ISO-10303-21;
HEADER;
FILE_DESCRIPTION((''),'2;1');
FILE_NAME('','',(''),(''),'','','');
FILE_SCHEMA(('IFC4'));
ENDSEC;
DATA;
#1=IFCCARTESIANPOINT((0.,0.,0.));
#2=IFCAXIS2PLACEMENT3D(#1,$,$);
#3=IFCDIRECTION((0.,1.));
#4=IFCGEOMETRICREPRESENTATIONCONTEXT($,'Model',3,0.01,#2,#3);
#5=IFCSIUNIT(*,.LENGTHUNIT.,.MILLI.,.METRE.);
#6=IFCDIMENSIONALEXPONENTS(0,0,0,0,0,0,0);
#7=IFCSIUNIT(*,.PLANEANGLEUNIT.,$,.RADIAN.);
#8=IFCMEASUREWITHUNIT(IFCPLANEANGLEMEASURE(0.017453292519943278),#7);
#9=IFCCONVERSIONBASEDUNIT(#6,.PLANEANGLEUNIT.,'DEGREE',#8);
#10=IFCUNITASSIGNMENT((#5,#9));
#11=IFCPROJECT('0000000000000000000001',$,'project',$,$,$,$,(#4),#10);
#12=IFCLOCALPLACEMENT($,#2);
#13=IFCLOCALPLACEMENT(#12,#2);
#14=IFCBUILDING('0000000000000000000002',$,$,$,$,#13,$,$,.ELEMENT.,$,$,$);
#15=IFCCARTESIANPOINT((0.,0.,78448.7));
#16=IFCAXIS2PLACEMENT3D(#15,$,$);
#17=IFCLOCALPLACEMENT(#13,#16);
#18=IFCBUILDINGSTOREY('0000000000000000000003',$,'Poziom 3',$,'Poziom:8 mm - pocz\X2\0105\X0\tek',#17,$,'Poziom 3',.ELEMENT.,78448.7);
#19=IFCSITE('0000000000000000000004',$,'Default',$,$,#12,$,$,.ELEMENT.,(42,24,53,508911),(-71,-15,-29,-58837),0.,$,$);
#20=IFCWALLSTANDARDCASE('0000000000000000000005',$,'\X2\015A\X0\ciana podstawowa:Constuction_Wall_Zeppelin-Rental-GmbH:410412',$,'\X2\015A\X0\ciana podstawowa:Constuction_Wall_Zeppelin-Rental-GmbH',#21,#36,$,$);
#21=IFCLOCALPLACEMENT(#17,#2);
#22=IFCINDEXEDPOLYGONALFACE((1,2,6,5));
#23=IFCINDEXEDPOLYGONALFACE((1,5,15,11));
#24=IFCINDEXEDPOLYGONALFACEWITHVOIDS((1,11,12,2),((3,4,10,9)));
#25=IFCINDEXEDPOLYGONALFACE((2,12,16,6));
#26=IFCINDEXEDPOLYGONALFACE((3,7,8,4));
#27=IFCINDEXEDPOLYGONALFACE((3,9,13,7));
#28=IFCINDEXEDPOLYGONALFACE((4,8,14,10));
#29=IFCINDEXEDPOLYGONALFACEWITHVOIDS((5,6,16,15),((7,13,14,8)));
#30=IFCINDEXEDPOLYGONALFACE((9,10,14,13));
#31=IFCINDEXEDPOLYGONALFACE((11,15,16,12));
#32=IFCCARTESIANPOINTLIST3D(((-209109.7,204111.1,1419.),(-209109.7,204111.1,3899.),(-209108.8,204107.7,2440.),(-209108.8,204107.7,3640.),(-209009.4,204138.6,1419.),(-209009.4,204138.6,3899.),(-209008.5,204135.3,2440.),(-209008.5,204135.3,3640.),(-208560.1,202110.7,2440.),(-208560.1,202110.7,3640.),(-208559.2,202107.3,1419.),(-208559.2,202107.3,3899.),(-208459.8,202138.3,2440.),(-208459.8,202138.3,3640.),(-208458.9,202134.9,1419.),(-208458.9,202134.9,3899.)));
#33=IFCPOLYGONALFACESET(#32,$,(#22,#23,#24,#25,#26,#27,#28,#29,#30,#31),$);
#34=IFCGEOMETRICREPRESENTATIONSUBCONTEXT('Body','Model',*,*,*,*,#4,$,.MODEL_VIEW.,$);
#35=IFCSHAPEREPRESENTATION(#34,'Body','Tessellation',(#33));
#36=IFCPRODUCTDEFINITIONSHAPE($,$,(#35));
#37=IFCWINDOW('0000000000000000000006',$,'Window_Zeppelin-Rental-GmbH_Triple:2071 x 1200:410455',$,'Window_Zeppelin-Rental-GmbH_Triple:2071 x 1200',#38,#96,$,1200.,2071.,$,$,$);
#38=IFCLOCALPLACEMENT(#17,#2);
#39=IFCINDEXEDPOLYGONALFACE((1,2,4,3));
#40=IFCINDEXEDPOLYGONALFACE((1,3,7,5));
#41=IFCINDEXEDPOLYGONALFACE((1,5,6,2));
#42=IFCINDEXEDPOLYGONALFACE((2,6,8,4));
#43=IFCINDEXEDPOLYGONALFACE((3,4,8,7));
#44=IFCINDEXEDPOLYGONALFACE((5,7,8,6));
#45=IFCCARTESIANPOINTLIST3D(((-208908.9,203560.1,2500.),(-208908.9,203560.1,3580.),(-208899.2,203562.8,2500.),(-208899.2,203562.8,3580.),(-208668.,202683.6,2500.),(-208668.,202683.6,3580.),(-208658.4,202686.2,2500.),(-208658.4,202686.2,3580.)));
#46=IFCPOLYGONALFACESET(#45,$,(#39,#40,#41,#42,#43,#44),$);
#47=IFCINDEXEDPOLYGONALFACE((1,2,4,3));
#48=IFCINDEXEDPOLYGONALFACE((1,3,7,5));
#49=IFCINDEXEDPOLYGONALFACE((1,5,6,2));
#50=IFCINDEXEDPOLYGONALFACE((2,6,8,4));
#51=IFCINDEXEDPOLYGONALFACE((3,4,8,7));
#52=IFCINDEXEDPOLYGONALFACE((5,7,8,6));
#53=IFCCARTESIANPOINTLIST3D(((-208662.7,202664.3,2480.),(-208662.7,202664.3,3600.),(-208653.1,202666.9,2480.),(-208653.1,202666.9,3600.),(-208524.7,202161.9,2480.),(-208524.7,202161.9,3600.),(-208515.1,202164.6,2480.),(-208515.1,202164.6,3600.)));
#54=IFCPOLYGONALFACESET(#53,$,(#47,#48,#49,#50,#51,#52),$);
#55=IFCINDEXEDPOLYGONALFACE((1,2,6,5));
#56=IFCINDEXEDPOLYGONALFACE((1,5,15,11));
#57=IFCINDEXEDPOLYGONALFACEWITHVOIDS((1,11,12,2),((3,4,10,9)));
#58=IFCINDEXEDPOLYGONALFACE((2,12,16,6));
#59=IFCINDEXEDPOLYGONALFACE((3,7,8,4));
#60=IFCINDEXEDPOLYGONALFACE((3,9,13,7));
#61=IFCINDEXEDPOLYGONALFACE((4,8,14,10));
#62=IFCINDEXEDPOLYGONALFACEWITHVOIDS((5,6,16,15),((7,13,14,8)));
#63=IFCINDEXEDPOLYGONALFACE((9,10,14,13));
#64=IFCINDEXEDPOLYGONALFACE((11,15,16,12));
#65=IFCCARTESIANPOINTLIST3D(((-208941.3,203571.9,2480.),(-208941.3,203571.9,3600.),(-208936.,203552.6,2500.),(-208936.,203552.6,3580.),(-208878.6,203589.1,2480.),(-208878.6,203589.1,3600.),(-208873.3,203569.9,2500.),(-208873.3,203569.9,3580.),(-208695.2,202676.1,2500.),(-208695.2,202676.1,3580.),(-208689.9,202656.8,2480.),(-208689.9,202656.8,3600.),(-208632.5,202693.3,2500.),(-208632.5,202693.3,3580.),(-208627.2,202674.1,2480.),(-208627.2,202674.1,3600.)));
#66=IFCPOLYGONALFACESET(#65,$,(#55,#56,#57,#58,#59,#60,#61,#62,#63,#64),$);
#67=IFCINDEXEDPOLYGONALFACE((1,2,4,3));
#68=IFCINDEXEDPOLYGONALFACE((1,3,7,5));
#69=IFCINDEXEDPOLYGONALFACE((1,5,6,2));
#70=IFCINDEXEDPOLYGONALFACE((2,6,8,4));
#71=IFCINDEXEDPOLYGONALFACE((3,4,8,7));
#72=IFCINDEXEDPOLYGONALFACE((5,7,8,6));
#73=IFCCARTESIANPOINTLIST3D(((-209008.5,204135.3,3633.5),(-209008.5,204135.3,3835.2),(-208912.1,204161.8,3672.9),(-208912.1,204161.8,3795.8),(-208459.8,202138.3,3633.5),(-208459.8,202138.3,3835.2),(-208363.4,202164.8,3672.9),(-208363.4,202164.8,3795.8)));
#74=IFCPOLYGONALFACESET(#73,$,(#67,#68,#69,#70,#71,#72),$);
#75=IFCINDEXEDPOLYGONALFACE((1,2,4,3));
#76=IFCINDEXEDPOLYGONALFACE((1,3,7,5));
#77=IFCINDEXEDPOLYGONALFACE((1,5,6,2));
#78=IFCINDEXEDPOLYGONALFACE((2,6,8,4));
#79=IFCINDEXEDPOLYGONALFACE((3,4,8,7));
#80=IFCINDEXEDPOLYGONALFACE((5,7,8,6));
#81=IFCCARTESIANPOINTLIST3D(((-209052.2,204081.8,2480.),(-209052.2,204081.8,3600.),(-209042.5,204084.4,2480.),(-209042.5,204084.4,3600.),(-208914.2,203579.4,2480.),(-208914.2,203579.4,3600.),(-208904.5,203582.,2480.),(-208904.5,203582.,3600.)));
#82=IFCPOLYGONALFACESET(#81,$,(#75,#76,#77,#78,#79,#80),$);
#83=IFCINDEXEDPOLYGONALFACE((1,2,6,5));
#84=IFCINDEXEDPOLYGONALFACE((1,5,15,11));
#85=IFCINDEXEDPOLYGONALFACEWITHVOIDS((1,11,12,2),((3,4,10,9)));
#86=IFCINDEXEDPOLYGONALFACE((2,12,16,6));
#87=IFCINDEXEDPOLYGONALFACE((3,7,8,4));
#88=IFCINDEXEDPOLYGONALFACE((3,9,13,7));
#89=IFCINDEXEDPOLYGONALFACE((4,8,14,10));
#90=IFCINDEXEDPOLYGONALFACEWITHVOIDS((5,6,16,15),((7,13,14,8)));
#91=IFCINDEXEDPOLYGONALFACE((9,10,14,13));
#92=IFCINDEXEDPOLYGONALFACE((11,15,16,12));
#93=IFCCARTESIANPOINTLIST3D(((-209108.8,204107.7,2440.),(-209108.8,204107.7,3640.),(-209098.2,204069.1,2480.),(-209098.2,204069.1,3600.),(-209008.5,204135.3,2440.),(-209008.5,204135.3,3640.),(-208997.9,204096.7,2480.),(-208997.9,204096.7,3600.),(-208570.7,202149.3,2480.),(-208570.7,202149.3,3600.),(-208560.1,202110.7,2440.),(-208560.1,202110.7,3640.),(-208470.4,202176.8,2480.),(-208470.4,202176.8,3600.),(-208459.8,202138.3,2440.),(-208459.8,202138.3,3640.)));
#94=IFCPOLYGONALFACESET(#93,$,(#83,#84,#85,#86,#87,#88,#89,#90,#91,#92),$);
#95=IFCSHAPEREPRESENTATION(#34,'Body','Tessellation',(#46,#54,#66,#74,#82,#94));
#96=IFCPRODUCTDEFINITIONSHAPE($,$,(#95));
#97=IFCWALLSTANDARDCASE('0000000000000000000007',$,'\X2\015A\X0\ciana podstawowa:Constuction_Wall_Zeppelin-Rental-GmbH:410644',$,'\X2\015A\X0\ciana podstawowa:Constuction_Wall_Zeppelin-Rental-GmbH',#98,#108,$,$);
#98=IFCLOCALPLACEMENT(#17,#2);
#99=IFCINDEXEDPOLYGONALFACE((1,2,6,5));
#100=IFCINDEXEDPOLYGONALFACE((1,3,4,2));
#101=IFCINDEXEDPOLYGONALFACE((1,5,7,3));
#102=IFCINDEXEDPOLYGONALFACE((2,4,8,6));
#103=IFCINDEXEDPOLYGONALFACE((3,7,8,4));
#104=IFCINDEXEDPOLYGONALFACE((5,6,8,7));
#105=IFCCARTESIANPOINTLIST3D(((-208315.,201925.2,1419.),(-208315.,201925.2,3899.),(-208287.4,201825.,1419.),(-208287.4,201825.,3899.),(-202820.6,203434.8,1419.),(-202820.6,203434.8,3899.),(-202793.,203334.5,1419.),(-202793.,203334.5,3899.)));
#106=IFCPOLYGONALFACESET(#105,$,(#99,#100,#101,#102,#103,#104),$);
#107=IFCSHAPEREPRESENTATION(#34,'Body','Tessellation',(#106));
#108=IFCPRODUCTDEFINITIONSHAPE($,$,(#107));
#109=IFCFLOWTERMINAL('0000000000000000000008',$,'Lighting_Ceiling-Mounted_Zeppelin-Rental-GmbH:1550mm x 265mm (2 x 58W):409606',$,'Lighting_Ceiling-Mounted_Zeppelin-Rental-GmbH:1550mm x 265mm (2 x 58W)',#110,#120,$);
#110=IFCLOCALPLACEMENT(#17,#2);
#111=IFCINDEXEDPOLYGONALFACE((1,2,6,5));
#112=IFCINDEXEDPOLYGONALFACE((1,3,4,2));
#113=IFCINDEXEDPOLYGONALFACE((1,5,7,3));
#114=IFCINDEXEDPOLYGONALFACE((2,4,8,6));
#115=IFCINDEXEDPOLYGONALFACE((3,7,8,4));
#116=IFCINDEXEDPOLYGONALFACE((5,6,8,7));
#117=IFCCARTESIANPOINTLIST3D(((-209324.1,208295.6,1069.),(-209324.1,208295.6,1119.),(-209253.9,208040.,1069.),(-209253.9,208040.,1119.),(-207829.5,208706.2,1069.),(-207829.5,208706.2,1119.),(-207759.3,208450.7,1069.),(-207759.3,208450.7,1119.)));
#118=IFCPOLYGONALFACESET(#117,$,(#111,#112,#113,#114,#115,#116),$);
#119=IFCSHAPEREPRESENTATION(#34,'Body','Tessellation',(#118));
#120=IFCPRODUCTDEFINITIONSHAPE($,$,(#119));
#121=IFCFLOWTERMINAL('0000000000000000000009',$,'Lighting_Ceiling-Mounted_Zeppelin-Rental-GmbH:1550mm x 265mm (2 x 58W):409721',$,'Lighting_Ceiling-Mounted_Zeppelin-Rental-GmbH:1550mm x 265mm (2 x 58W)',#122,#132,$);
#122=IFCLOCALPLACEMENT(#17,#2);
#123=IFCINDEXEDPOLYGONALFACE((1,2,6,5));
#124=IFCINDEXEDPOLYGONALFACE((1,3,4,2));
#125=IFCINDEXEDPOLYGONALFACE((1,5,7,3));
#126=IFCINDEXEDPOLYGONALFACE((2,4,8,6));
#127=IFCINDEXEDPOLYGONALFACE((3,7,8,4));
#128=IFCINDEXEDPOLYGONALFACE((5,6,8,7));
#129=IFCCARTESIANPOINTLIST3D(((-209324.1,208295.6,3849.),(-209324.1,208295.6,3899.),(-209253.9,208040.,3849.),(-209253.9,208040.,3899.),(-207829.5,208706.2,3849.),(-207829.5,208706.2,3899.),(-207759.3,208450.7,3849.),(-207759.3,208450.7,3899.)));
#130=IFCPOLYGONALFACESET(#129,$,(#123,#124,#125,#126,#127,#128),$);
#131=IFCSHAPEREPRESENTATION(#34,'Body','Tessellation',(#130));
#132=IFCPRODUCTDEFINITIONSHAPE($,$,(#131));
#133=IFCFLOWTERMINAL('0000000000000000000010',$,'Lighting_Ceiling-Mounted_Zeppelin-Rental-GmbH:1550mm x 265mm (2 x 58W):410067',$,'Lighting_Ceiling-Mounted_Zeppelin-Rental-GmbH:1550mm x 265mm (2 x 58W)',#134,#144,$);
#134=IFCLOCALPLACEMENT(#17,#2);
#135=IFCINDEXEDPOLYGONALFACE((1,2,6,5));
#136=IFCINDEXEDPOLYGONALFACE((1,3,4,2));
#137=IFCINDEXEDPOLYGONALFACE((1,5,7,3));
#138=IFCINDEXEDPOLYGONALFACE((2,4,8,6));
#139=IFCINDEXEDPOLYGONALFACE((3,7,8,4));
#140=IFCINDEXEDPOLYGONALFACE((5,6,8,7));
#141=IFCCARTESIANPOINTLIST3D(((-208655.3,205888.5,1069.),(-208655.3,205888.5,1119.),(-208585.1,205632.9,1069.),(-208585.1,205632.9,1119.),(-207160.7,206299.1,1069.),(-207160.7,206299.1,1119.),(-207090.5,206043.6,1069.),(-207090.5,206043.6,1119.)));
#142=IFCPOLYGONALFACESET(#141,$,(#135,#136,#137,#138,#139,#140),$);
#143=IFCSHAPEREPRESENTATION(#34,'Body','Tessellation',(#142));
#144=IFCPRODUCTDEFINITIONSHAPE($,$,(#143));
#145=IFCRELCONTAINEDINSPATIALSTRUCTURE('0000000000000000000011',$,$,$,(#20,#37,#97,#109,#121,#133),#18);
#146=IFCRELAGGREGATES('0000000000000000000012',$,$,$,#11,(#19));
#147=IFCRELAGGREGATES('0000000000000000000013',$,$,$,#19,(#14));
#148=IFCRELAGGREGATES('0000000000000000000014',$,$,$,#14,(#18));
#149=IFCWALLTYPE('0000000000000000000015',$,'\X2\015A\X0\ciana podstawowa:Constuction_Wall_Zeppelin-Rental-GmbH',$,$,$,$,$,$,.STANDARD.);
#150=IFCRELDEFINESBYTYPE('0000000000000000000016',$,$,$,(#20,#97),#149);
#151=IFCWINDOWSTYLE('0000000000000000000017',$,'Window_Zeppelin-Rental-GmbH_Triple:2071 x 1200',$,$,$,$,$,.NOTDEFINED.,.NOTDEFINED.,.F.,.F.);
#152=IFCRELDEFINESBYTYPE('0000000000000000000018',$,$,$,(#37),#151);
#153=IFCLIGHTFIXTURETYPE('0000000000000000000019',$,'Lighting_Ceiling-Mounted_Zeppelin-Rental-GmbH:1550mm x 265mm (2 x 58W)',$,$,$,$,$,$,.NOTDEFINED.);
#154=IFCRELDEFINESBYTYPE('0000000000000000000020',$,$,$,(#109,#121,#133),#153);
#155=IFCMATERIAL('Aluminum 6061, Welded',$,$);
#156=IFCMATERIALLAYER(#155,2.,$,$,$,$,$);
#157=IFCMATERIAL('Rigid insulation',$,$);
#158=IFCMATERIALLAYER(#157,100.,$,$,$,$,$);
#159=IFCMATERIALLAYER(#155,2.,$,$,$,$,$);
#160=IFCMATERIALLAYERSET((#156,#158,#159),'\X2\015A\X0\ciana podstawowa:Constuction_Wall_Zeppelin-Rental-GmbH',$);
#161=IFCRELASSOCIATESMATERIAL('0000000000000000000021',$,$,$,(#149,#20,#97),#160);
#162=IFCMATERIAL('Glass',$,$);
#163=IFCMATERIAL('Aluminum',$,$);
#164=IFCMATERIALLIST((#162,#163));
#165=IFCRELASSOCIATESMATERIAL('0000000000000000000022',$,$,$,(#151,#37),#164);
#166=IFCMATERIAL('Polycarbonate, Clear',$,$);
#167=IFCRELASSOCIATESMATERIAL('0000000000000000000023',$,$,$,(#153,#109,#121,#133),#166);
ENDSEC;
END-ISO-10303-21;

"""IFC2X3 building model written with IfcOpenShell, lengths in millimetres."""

from ifc_helpers import new_model, entity, si_unit, converted_unit, direction, frame, frame_2d, origin, origin_2d_with_axis, place, context, subcontext, project, spatial, polyline, rectangle, outline, extrude, source, transform, mapped, material, material_list, layer, layer_set, layer_usage, type_object, type_shapes, element, fill, save


model = new_model("IFC2X3")

# Units and contexts
model_context = context("Model", 3, precision=0.01, world=origin(), true_north=direction((0.0, 1.0)))
body_context = subcontext(model_context, "Body", "Model", "MODEL_VIEW")
ifc_project = project(units=[si_unit("LENGTHUNIT", "METRE", prefix="MILLI"), converted_unit("PLANEANGLEUNIT", "DEGREE", entity("IfcPlaneAngleMeasure", 0.017453292519943278), si_unit("PLANEANGLEUNIT", "RADIAN"), dimensions=[0, 0, 0, 0, 0, 0, 0])], contexts=[model_context])

# Site, building, storey
site_placement = place(None, origin())
site = spatial("IfcSite", under=ifc_project, at=site_placement, Name="Default", CompositionType="ELEMENT", RefLatitude=(42, 24, 53, 508911), RefLongitude=(-71, -15, -29, -58837), RefElevation=0.0)
building_placement = place(site_placement, origin())
building = spatial("IfcBuilding", under=site, at=building_placement, CompositionType="ELEMENT")
storey_placement = place(building_placement, frame((0.0, 0.0, 78448.7)))
storey = spatial("IfcBuildingStorey", under=building, at=storey_placement, Name="Poziom 3", ObjectType="Poziom:8 mm - początek", LongName="Poziom 3", CompositionType="ELEMENT", Elevation=78448.7)

# Shared definitions
ifc_material_1 = material(Name="Aluminum 6061, Welded")
ifc_layer_1 = layer(ifc_material_1, 2.0)
ifc_material_2 = material(Name="Rigid insulation")
ifc_layer_2 = layer(ifc_material_2, 100.0)
ifc_layer_3 = layer(ifc_material_1, 2.0)
ifc_layer_set_1 = layer_set([ifc_layer_1, ifc_layer_2, ifc_layer_3], Name="Ściana podstawowa:Constuction_Wall_Zeppelin-Rental-GmbH")
wall_type_1 = type_object("IfcWallType", Name="Ściana podstawowa:Constuction_Wall_Zeppelin-Rental-GmbH", PredefinedType="STANDARD", material=ifc_layer_set_1)

# Shared definitions
ifc_material_3 = material(Name="Glass")
ifc_material_4 = material(Name="Aluminum")
ifc_material_list = material_list([ifc_material_3, ifc_material_4])
window_style = type_object("IfcWindowStyle", Name="Window_Zeppelin-Rental-GmbH_Triple:2071 x 1200", ConstructionType="NOTDEFINED", OperationType="NOTDEFINED", ParameterTakesPrecedence=False, Sizeable=False, material=ifc_material_list)
shared_shape_1 = source(origin(), body_context, "Body", "SweptSolid", [
    extrude(rectangle(XDim=10.0, YDim=909.0, at=origin_2d_with_axis()), frame((1035.5, 52.7, 60.0), z_axis=(0.0, 0.0, 1.0), x_axis=(0.0, -1.0, 0.0)), (0.0, 0.0, 1.0), 1080.0),
    extrude(rectangle(XDim=521.0, YDim=10.0, at=frame_2d((0.0, 0.0), x_axis=(1.0, 0.0))), frame((300.5, 52.7, 40.0), z_axis=(0.0, 0.0, 1.0), x_axis=(-1.0, 0.0, 0.0)), (0.0, 0.0, 1.0), 1120.0),
    extrude(outline(polyline([(-474.5, -560.0), (474.5, -560.0), (474.5, 560.0), (-474.5, 560.0), (-474.5, -560.0)]), holes=[polyline([(-454.5, 540.0), (454.5, 540.0), (454.5, -540.0), (-454.5, -540.0), (-454.5, 540.0)])]), frame((1035.5, 85.8, 600.0), z_axis=(0.0, -1.0, 0.0), x_axis=(1.0, 0.0, 0.0)), (0.0, 0.0, 1.0), 65.0),
    extrude(outline(polyline([(-24.0, -75.5), (83.5, -75.5), (9.6, 112.1), (-69.0, 38.9), (-24.0, -75.5)])), frame((2071.0, -48.7, 1294.4), z_axis=(-1.0, 0.0, 0.0), x_axis=(0.0, 0.930458, 0.366398)), (0.0, 0.0, 1.0), 2071.0),
    extrude(rectangle(XDim=10.0, YDim=521.0, at=frame_2d((0.0, 0.0), x_axis=(1.0, 0.0))), frame((1770.5, 52.7, 40.0), z_axis=(0.0, 0.0, 1.0), x_axis=(0.0, -1.0, 0.0)), (0.0, 0.0, 1.0), 1120.0),
    extrude(outline(polyline([(-1035.5, -600.0), (1035.5, -600.0), (1035.5, 600.0), (-1035.5, 600.0), (-1035.5, -600.0)]), holes=[polyline([(-995.5, 560.0), (995.5, 560.0), (995.5, -560.0), (-995.5, -560.0), (-995.5, 560.0)])]), frame((1035.5, 105.3, 600.0), z_axis=(0.0, -1.0, 0.0), x_axis=(1.0, 0.0, 0.0)), (0.0, 0.0, 1.0), 104.0),
])
type_shapes(window_style, [shared_shape_1])

# Wall, opening, window
ifc_layer_usage_1 = layer_usage(ifc_layer_set_1, "AXIS2", "NEGATIVE", 52.0)
wall_1_placement = place(storey_placement, frame((-208509.0, 202121.1, 1419.0), z_axis=(0.0, 0.0, 1.0), x_axis=(-0.264931, 0.964267, 0.0)))
wall_1 = element("IfcWallStandardCase", 1, at=wall_1_placement, inside=storey, type_object=wall_type_1, material=ifc_layer_usage_1, Name="Ściana podstawowa:Constuction_Wall_Zeppelin-Rental-GmbH:410412", ObjectType="Ściana podstawowa:Constuction_Wall_Zeppelin-Rental-GmbH", context=body_context, shape_type="SweptSolid", body=[
    extrude(rectangle(XDim=2078.0, YDim=104.0, at=frame_2d((1039.0, 0.0), x_axis=(-1.0, 0.0))), origin(), (0.0, 0.0, 1.0), 2480.0),
])
opening_1_placement = place(wall_1_placement, frame((3.5, -52.0, 1021.0)))
opening_1 = element("IfcOpeningElement", 2, at=opening_1_placement, cuts=wall_1, ObjectType="Opening", context=body_context, shape_type="SweptSolid", body=[
    extrude(rectangle(XDim=1200.0, YDim=2071.0, at=frame_2d((600.0, 1035.5), x_axis=(1.0, 0.0))), frame((0.0, 0.0, 0.0), z_axis=(0.0, 1.0, 0.0), x_axis=(0.0, 0.0, 1.0)), (0.0, 0.0, 1.0), 104.0),
])
window_1_placement = place(opening_1_placement, frame((0.0, -1.3, 0.0)))
window_1 = element("IfcWindow", 3, at=window_1_placement, inside=storey, type_object=window_style, material=ifc_material_list, Name="Window_Zeppelin-Rental-GmbH_Triple:2071 x 1200:410455", ObjectType="Window_Zeppelin-Rental-GmbH_Triple:2071 x 1200", OverallHeight=1200.0, OverallWidth=2071.0, context=body_context, shape_type="MappedRepresentation", body=[
    mapped(shared_shape_1, transform((0.0, 0.0, 0.0), scale=1.0)),
])
fill(opening_1, window_1)

# Wall
ifc_layer_usage_2 = layer_usage(ifc_layer_set_1, "AXIS2", "NEGATIVE", 52.0)
wall_2_placement = place(storey_placement, frame((-208301.2, 201875.1, 1419.0), z_axis=(0.0, 0.0, 1.0), x_axis=(0.964267, 0.264931, 0.0)))
element("IfcWallStandardCase", 4, at=wall_2_placement, inside=storey, type_object=wall_type_1, material=ifc_layer_usage_2, Name="Ściana podstawowa:Constuction_Wall_Zeppelin-Rental-GmbH:410644", ObjectType="Ściana podstawowa:Constuction_Wall_Zeppelin-Rental-GmbH", context=body_context, shape_type="SweptSolid", body=[
    extrude(rectangle(XDim=5698.0, YDim=104.0, at=frame_2d((2849.0, 0.0), x_axis=(-1.0, 0.0))), origin(), (0.0, 0.0, 1.0), 2480.0),
])

# Flow terminals
ifc_material_5 = material(Name="Polycarbonate, Clear")
light_fixture_type = type_object("IfcLightFixtureType", Name="Lighting_Ceiling-Mounted_Zeppelin-Rental-GmbH:1550mm x 265mm (2 x 58W)", PredefinedType="NOTDEFINED", material=ifc_material_5)
shared_shape_2 = source(origin(), body_context, "Body", "SweptSolid", [
    extrude(rectangle(XDim=1550.0, YDim=265.0, at=origin_2d_with_axis()), frame((0.0, 0.0, 0.0), z_axis=(0.0, 0.0, 1.0), x_axis=(-1.0, 0.0, 0.0)), (0.0, 0.0, 1.0), 50.0),
])
type_shapes(light_fixture_type, [shared_shape_2])
for number, where, z_axis, x_axis, name in (
    (5, (-208541.7, 208373.1, 1119.0), (0.0, 0.0, -1.0), (-0.964267, -0.264931, 0.0), "Lighting_Ceiling-Mounted_Zeppelin-Rental-GmbH:1550mm x 265mm (2 x 58W):409606"),
    (6, (-208541.7, 208373.1, 3899.0), (0.0, 0.0, -1.0), (-0.964267, -0.264931, 0.0), "Lighting_Ceiling-Mounted_Zeppelin-Rental-GmbH:1550mm x 265mm (2 x 58W):409721"),
    (7, (-207872.9, 205966.0, 1119.0), (0.0, 0.0, -1.0), (-0.964267, -0.264931, 0.0), "Lighting_Ceiling-Mounted_Zeppelin-Rental-GmbH:1550mm x 265mm (2 x 58W):410067"),
):
    element("IfcFlowTerminal", number, at=place(storey_placement, frame(where, z_axis=z_axis, x_axis=x_axis)), inside=storey, type_object=light_fixture_type, material=ifc_material_5, Name=name, ObjectType="Lighting_Ceiling-Mounted_Zeppelin-Rental-GmbH:1550mm x 265mm (2 x 58W)", context=body_context, shape_type="MappedRepresentation", body=[
        mapped(shared_shape_2, transform((0.0, 0.0, 0.0), scale=1.0)),
    ])

save(model, "model.ifc")
